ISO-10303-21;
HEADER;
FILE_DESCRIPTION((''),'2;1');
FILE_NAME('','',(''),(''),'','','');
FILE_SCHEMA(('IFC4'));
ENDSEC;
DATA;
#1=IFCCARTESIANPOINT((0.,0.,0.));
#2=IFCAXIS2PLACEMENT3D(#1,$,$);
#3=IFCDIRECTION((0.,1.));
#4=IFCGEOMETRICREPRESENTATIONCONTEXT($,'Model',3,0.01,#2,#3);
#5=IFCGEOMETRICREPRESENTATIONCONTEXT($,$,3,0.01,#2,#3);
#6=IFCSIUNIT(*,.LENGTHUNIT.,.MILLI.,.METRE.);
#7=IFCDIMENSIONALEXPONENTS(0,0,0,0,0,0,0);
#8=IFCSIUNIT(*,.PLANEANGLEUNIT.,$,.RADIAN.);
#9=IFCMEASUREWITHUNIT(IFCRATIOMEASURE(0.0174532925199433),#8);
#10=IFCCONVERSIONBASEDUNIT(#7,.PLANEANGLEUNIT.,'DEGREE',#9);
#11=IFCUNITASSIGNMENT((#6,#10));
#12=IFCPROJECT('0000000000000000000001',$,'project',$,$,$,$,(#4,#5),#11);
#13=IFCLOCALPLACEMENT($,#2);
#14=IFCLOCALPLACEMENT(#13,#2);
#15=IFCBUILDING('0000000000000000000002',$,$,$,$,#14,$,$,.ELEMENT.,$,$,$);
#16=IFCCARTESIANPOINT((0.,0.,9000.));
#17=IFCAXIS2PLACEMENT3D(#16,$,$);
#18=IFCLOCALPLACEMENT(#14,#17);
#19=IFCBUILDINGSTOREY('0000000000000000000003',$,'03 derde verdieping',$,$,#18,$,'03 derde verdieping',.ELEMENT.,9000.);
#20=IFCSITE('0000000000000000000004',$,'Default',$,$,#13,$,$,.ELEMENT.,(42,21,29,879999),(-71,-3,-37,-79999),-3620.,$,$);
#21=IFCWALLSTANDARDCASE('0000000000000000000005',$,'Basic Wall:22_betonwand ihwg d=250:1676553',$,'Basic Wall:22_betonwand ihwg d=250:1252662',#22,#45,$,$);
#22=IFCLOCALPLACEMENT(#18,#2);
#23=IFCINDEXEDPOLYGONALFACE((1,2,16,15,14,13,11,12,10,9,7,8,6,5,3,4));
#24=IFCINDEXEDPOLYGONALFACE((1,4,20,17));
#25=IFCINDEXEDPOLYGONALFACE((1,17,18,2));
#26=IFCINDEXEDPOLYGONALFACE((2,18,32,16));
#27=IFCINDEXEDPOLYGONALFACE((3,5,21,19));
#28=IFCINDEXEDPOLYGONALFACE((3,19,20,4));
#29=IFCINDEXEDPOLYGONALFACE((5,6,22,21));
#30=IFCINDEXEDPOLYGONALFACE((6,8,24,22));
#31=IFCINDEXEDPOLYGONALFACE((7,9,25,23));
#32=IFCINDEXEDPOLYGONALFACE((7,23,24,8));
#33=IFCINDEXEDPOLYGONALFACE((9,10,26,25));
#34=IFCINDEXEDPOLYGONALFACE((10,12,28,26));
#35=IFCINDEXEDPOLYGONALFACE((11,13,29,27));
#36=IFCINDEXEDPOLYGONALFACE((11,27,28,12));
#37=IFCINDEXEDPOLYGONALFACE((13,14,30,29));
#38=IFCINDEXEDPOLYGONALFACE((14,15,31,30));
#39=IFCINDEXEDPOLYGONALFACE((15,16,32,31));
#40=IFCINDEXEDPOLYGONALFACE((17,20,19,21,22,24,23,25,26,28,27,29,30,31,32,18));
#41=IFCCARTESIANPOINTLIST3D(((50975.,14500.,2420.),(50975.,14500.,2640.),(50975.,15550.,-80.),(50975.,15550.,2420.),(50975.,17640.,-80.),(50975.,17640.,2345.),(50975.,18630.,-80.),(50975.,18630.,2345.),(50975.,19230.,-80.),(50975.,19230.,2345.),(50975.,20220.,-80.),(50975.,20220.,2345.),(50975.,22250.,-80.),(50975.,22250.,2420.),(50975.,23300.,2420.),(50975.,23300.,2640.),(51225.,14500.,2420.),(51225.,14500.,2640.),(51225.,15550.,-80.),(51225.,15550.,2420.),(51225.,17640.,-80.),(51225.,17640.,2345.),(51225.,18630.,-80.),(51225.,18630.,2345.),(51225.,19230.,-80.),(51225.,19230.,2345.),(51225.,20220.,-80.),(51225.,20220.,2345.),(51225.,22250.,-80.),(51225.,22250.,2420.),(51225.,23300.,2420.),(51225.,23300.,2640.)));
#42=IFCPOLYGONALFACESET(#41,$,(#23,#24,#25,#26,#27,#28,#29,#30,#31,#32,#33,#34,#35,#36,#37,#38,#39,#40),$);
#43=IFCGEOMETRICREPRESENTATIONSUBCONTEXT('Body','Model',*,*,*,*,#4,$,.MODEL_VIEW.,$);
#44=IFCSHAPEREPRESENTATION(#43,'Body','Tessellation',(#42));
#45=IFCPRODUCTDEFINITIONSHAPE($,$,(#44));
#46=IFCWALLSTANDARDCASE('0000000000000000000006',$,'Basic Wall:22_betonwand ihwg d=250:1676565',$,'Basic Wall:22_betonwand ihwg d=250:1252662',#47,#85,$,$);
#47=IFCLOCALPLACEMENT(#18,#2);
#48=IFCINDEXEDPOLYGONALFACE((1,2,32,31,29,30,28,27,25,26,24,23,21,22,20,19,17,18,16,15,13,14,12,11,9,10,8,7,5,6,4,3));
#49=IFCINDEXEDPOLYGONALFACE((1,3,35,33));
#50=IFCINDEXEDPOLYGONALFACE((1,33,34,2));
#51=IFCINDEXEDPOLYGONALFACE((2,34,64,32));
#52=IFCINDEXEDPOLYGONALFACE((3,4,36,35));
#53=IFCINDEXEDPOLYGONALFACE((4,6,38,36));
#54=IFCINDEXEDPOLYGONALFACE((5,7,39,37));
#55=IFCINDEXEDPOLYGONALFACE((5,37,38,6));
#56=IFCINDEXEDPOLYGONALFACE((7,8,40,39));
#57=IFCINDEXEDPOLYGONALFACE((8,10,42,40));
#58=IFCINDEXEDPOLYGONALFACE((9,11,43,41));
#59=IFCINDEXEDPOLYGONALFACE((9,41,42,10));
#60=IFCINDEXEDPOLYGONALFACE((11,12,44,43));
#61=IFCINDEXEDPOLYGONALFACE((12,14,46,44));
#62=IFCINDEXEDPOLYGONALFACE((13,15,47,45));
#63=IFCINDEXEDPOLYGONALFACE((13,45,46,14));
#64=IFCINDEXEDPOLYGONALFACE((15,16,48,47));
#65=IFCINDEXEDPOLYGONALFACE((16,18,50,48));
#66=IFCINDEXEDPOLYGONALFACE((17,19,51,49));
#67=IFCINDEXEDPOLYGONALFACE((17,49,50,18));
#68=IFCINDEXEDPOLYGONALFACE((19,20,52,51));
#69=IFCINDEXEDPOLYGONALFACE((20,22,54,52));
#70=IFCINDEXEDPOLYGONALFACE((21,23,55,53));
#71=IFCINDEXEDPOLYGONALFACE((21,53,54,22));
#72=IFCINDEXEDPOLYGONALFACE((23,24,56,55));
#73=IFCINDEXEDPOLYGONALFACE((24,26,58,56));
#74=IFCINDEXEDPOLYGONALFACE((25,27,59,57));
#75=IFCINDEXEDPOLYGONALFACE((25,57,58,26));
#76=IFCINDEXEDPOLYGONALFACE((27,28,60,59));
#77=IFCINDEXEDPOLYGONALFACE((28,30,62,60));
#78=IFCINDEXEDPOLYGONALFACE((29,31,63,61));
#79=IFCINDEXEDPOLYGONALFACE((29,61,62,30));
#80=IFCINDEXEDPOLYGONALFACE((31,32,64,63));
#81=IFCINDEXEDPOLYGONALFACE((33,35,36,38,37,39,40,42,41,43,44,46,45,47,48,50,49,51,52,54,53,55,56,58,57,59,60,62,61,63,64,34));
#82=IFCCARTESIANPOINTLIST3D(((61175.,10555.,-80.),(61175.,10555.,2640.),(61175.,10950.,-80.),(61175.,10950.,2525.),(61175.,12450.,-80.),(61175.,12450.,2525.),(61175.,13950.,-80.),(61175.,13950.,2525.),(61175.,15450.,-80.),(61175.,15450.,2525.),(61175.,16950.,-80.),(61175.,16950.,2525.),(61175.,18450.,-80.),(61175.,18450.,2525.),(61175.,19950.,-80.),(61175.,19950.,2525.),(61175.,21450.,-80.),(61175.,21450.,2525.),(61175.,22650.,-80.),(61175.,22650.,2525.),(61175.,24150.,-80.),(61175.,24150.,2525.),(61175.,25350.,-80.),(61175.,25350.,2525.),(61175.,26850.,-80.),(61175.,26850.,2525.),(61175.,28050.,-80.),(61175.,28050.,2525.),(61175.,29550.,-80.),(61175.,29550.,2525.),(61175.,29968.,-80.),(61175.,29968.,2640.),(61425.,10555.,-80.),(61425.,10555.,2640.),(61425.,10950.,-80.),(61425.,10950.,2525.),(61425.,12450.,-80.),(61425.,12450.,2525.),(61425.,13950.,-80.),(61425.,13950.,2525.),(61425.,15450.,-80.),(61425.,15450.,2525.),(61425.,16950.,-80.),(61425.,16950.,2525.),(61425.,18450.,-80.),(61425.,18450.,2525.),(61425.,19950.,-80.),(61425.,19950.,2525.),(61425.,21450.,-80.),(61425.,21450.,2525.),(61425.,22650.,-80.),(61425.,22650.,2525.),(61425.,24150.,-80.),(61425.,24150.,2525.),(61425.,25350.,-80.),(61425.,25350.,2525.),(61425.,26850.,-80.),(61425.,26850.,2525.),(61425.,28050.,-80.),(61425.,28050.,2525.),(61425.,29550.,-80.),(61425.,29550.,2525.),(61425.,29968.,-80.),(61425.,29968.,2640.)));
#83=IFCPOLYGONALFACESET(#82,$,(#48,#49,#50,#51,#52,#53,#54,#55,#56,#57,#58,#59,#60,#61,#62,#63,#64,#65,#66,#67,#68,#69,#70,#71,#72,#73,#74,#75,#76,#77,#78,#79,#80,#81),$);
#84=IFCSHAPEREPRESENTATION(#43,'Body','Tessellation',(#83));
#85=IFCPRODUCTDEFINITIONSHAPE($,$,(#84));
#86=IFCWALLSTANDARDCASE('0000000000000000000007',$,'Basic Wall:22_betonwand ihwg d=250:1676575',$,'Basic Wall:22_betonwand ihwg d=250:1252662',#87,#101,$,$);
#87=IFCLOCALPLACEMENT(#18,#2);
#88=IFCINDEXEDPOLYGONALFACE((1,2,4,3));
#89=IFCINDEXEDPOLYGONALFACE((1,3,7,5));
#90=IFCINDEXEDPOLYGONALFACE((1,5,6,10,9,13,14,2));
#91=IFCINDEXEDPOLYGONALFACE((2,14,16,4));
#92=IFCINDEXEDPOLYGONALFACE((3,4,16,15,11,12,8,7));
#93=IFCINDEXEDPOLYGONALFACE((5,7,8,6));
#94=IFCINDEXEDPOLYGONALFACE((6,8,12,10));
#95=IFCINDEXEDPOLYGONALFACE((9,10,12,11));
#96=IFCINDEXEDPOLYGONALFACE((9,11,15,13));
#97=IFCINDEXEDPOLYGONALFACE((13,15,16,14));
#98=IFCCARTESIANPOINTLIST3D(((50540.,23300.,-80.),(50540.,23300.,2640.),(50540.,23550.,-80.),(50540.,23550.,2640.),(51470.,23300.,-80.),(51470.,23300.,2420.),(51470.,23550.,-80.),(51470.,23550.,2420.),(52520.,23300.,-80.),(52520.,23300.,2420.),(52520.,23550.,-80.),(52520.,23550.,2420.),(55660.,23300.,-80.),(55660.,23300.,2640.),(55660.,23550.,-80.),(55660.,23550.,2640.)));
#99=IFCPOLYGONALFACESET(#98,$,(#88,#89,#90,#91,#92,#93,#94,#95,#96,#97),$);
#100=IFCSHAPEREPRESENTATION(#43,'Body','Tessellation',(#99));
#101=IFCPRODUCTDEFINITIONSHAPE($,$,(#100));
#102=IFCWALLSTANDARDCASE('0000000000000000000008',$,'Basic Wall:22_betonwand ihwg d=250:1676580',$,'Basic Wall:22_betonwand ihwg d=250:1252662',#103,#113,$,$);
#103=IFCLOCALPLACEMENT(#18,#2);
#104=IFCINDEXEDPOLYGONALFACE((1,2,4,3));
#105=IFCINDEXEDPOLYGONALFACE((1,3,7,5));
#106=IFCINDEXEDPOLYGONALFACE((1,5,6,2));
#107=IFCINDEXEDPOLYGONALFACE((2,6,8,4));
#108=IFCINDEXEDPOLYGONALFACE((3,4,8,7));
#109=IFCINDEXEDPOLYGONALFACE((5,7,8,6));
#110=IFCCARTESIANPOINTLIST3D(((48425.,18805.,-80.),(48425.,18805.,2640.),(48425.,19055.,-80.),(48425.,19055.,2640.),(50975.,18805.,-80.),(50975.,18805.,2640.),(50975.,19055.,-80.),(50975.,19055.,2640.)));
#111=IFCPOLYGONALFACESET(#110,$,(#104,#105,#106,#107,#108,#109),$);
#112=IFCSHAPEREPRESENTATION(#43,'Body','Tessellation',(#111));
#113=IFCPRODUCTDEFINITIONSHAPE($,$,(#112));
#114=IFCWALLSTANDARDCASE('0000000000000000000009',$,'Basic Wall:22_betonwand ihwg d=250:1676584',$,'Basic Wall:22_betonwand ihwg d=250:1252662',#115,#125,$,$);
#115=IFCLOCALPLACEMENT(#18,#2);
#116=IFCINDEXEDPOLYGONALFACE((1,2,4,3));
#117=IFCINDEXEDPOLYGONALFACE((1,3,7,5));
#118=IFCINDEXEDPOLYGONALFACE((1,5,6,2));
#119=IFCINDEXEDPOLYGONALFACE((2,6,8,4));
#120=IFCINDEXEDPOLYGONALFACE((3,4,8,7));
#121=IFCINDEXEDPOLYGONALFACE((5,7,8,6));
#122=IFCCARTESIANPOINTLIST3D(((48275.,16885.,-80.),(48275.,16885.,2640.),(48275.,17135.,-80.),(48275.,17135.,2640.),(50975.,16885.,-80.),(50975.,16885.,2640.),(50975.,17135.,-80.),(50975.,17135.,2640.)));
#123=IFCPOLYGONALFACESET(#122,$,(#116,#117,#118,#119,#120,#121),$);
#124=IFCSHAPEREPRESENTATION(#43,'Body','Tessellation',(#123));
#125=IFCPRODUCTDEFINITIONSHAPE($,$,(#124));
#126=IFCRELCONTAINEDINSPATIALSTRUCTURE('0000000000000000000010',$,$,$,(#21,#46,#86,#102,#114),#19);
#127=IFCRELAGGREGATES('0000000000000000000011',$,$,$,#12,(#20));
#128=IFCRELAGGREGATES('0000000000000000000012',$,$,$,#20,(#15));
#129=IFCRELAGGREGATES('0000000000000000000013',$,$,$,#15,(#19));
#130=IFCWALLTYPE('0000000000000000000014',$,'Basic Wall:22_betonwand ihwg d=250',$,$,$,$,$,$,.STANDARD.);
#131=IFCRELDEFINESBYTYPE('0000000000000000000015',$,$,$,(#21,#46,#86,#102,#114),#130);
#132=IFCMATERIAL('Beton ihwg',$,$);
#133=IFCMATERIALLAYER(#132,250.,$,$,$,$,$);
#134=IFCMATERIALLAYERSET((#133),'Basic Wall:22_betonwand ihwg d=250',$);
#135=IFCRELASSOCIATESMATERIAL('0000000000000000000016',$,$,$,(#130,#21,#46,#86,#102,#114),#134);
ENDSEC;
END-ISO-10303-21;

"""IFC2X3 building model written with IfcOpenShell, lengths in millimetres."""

from ifc_helpers import new_model, entity, si_unit, converted_unit, direction, frame, frame_2d, origin, place, context, subcontext, project, spatial, rectangle, extrude, material, layer, layer_set, layer_usage, type_object, element, save


model = new_model("IFC2X3")

# Units and contexts
model_context = context("Model", 3, precision=0.01, world=origin(), true_north=direction((0.0, 1.0)))
context_of_model = context(None, 3, precision=0.01, world=origin(), true_north=direction((0.0, 1.0)))
body_context = subcontext(model_context, "Body", "Model", "MODEL_VIEW")
ifc_project = project(units=[si_unit("LENGTHUNIT", "METRE", prefix="MILLI"), converted_unit("PLANEANGLEUNIT", "DEGREE", entity("IfcRatioMeasure", 0.0174532925199433), si_unit("PLANEANGLEUNIT", "RADIAN"), dimensions=[0, 0, 0, 0, 0, 0, 0])], contexts=[model_context, context_of_model])

# Site, building, storey
site_placement = place(None, origin())
site = spatial("IfcSite", under=ifc_project, at=site_placement, Name="Default", CompositionType="ELEMENT", RefLatitude=(42, 21, 29, 879999), RefLongitude=(-71, -3, -37, -79999), RefElevation=-3620.0)
building_placement = place(site_placement, origin())
building = spatial("IfcBuilding", under=site, at=building_placement, CompositionType="ELEMENT")
storey_placement = place(building_placement, frame((0.0, 0.0, 9000.0)))
storey = spatial("IfcBuildingStorey", under=building, at=storey_placement, Name="03 derde verdieping", LongName="03 derde verdieping", CompositionType="ELEMENT", Elevation=9000.0)

# Walls, openings
ifc_material_1 = material(Name="Beton ihwg")
ifc_layer_1 = layer(ifc_material_1, 250.0)
ifc_layer_set_1 = layer_set([ifc_layer_1], Name="Basic Wall:22_betonwand ihwg d=250")
ifc_layer_usage_1 = layer_usage(ifc_layer_set_1, "AXIS2", "NEGATIVE", 125.0)
wall_type_1 = type_object("IfcWallType", Name="Basic Wall:22_betonwand ihwg d=250", PredefinedType="STANDARD", material=ifc_layer_set_1)
wall_1_placement = place(storey_placement, frame((51100.0, 23300.0, -80.0), z_axis=(0.0, 0.0, 1.0), x_axis=(0.0, -1.0, 0.0)))
wall_1 = element("IfcWallStandardCase", 1, at=wall_1_placement, inside=storey, type_object=wall_type_1, material=ifc_layer_usage_1, Name="Basic Wall:22_betonwand ihwg d=250:1676553", ObjectType="Basic Wall:22_betonwand ihwg d=250:1252662", context=body_context, shape_type="SweptSolid", body=[
    extrude(rectangle(XDim=8800.0, YDim=250.0, at=frame_2d((4400.0, 0.0), x_axis=(-1.0, 0.0))), origin(), (0.0, 0.0, 1.0), 2720.0),
])
opening_1_placement = place(wall_1_placement, frame((23300.0, -51100.0, 80.0), z_axis=(0.0, 0.0, 1.0), x_axis=(0.0, 1.0, 0.0)))
element("IfcOpeningElement", 2, at=opening_1_placement, cuts=wall_1, ObjectType="Opening", context=body_context, shape_type="SweptSolid", body=[
    extrude(rectangle(XDim=2500.0, YDim=1050.0, at=frame_2d((0.0, 0.0), x_axis=(0.0, 1.0))), frame((50700.0, 15025.0, 1170.0), z_axis=(1.0, 0.0, 0.0), x_axis=(0.0, -1.0, 0.0)), (0.0, 0.0, 1.0), 800.0),
])
opening_2_placement = place(wall_1_placement, frame((23300.0, -51100.0, 80.0), z_axis=(0.0, 0.0, 1.0), x_axis=(0.0, 1.0, 0.0)))
element("IfcOpeningElement", 3, at=opening_2_placement, cuts=wall_1, ObjectType="Opening", context=body_context, shape_type="SweptSolid", body=[
    extrude(rectangle(XDim=2425.0, YDim=990.0, at=frame_2d((0.0, 0.0), x_axis=(1.0, 0.0))), frame((50700.0, 19725.0, 1132.5), z_axis=(1.0, 0.0, 0.0), x_axis=(0.0, 0.0, -1.0)), (0.0, 0.0, 1.0), 800.0),
])
opening_3_placement = place(wall_1_placement, frame((23300.0, -51100.0, 80.0), z_axis=(0.0, 0.0, 1.0), x_axis=(0.0, 1.0, 0.0)))
element("IfcOpeningElement", 4, at=opening_3_placement, cuts=wall_1, ObjectType="Opening", context=body_context, shape_type="SweptSolid", body=[
    extrude(rectangle(XDim=2425.0, YDim=990.0, at=frame_2d((0.0, 0.0), x_axis=(1.0, 0.0))), frame((50700.0, 18135.0, 1132.5), z_axis=(1.0, 0.0, 0.0), x_axis=(0.0, 0.0, -1.0)), (0.0, 0.0, 1.0), 800.0),
])
opening_4_placement = place(wall_1_placement, frame((23300.0, -51100.0, 80.0), z_axis=(0.0, 0.0, 1.0), x_axis=(0.0, 1.0, 0.0)))
element("IfcOpeningElement", 5, at=opening_4_placement, cuts=wall_1, ObjectType="Opening", context=body_context, shape_type="SweptSolid", body=[
    extrude(rectangle(XDim=2500.0, YDim=1050.0, at=frame_2d((0.0, 0.0), x_axis=(1.0, 0.0))), frame((50700.0, 22775.0, 1170.0), z_axis=(1.0, 0.0, 0.0), x_axis=(0.0, 0.0, -1.0)), (0.0, 0.0, 1.0), 800.0),
])
ifc_layer_usage_2 = layer_usage(ifc_layer_set_1, "AXIS2", "POSITIVE", -125.0)
wall_2_placement = place(storey_placement, frame((61300.0, 29968.0, -80.0), z_axis=(0.0, 0.0, 1.0), x_axis=(0.0, -1.0, 0.0)))
wall_2 = element("IfcWallStandardCase", 6, at=wall_2_placement, inside=storey, type_object=wall_type_1, material=ifc_layer_usage_2, Name="Basic Wall:22_betonwand ihwg d=250:1676565", ObjectType="Basic Wall:22_betonwand ihwg d=250:1252662", context=body_context, shape_type="SweptSolid", body=[
    extrude(rectangle(XDim=19413.0, YDim=250.0, at=frame_2d((9706.5, 0.0), x_axis=(-1.0, 0.0))), origin(), (0.0, 0.0, 1.0), 2720.0),
])
opening_5_placement = place(wall_2_placement, frame((29968.0, -61300.0, 80.0), z_axis=(0.0, 0.0, 1.0), x_axis=(0.0, 1.0, 0.0)))
element("IfcOpeningElement", 7, at=opening_5_placement, cuts=wall_2, ObjectType="Opening", context=body_context, shape_type="SweptSolid", body=[
    extrude(rectangle(XDim=2605.0, YDim=1500.0, at=frame_2d((0.0, 0.0), x_axis=(1.0, 0.0))), frame((59901.0, 28800.0, 1222.5), z_axis=(1.0, 0.0, 0.0), x_axis=(0.0, 0.0, -1.0)), (0.0, 0.0, 1.0), 3048.0),
])
opening_6_placement = place(wall_2_placement, frame((29968.0, -61300.0, 80.0), z_axis=(0.0, 0.0, 1.0), x_axis=(0.0, 1.0, 0.0)))
element("IfcOpeningElement", 8, at=opening_6_placement, cuts=wall_2, ObjectType="Opening", context=body_context, shape_type="SweptSolid", body=[
    extrude(rectangle(XDim=2605.0, YDim=1500.0, at=frame_2d((0.0, 0.0), x_axis=(1.0, 0.0))), frame((59901.0, 26100.0, 1222.5), z_axis=(1.0, 0.0, 0.0), x_axis=(0.0, 0.0, -1.0)), (0.0, 0.0, 1.0), 3048.0),
])
opening_7_placement = place(wall_2_placement, frame((29968.0, -61300.0, 80.0), z_axis=(0.0, 0.0, 1.0), x_axis=(0.0, 1.0, 0.0)))
element("IfcOpeningElement", 9, at=opening_7_placement, cuts=wall_2, ObjectType="Opening", context=body_context, shape_type="SweptSolid", body=[
    extrude(rectangle(XDim=2605.0, YDim=1500.0, at=frame_2d((0.0, 0.0), x_axis=(1.0, 0.0))), frame((59901.0, 23400.0, 1222.5), z_axis=(1.0, 0.0, 0.0), x_axis=(0.0, 0.0, -1.0)), (0.0, 0.0, 1.0), 3048.0),
])
opening_8_placement = place(wall_2_placement, frame((29968.0, -61300.0, 80.0), z_axis=(0.0, 0.0, 1.0), x_axis=(0.0, 1.0, 0.0)))
element("IfcOpeningElement", 10, at=opening_8_placement, cuts=wall_2, ObjectType="Opening", context=body_context, shape_type="SweptSolid", body=[
    extrude(rectangle(XDim=2605.0, YDim=1500.0, at=frame_2d((0.0, 0.0), x_axis=(1.0, 0.0))), frame((59901.0, 17700.0, 1222.5), z_axis=(1.0, 0.0, 0.0), x_axis=(0.0, 0.0, -1.0)), (0.0, 0.0, 1.0), 3048.0),
])
opening_9_placement = place(wall_2_placement, frame((29968.0, -61300.0, 80.0), z_axis=(0.0, 0.0, 1.0), x_axis=(0.0, 1.0, 0.0)))
element("IfcOpeningElement", 11, at=opening_9_placement, cuts=wall_2, ObjectType="Opening", context=body_context, shape_type="SweptSolid", body=[
    extrude(rectangle(XDim=2605.0, YDim=1500.0, at=frame_2d((0.0, 0.0), x_axis=(1.0, 0.0))), frame((59901.0, 14700.0, 1222.5), z_axis=(1.0, 0.0, 0.0), x_axis=(0.0, 0.0, -1.0)), (0.0, 0.0, 1.0), 3048.0),
])
opening_10_placement = place(wall_2_placement, frame((29968.0, -61300.0, 80.0), z_axis=(0.0, 0.0, 1.0), x_axis=(0.0, 1.0, 0.0)))
element("IfcOpeningElement", 12, at=opening_10_placement, cuts=wall_2, ObjectType="Opening", context=body_context, shape_type="SweptSolid", body=[
    extrude(rectangle(XDim=2605.0, YDim=1500.0, at=frame_2d((0.0, 0.0), x_axis=(1.0, 0.0))), frame((59901.0, 20700.0, 1222.5), z_axis=(1.0, 0.0, 0.0), x_axis=(0.0, 0.0, -1.0)), (0.0, 0.0, 1.0), 3048.0),
])
opening_11_placement = place(wall_2_placement, frame((29968.0, -61300.0, 80.0), z_axis=(0.0, 0.0, 1.0), x_axis=(0.0, 1.0, 0.0)))
element("IfcOpeningElement", 13, at=opening_11_placement, cuts=wall_2, ObjectType="Opening", context=body_context, shape_type="SweptSolid", body=[
    extrude(rectangle(XDim=2605.0, YDim=1500.0, at=frame_2d((0.0, 0.0), x_axis=(1.0, 0.0))), frame((59901.0, 11700.0, 1222.5), z_axis=(1.0, 0.0, 0.0), x_axis=(0.0, 0.0, -1.0)), (0.0, 0.0, 1.0), 3048.0),
])
ifc_layer_usage_3 = layer_usage(ifc_layer_set_1, "AXIS2", "POSITIVE", -125.0)
wall_3_placement = place(storey_placement, frame((55660.0, 23425.0, -80.0), z_axis=(0.0, 0.0, 1.0), x_axis=(-1.0, 0.0, 0.0)))
wall_3 = element("IfcWallStandardCase", 14, at=wall_3_placement, inside=storey, type_object=wall_type_1, material=ifc_layer_usage_3, Name="Basic Wall:22_betonwand ihwg d=250:1676575", ObjectType="Basic Wall:22_betonwand ihwg d=250:1252662", context=body_context, shape_type="SweptSolid", body=[
    extrude(rectangle(XDim=5120.0, YDim=250.0, at=frame_2d((2560.0, 0.0), x_axis=(-1.0, 0.0))), origin(), (0.0, 0.0, 1.0), 2720.0),
])
opening_12_placement = place(wall_3_placement, origin())
element("IfcOpeningElement", 15, at=opening_12_placement, cuts=wall_3, ObjectType="Opening", context=body_context, shape_type="SweptSolid", body=[
    extrude(rectangle(XDim=2500.0, YDim=800.0, at=frame_2d((0.0, 0.0), x_axis=(0.0, 1.0))), frame((4560.0, 125.0, 1250.0), z_axis=(0.0, 1.0, 0.0), x_axis=(1.0, 0.0, 0.0)), (0.0, 0.0, 1.0), 1050.0),
])
opening_13_placement = place(wall_3_placement, origin())
element("IfcOpeningElement", 16, at=opening_13_placement, cuts=wall_3, ObjectType="Opening", context=body_context, shape_type="SweptSolid", body=[
    extrude(rectangle(XDim=2500.0, YDim=800.0, at=frame_2d((0.0, 0.0), x_axis=(0.0, 1.0))), frame((2735.0, 125.0, 1250.0), z_axis=(0.0, 1.0, 0.0), x_axis=(1.0, 0.0, 0.0)), (0.0, 0.0, 1.0), 1034.0),
])
opening_14_placement = place(wall_3_placement, frame((55660.0, 23425.0, 80.0), z_axis=(0.0, 0.0, 1.0), x_axis=(-1.0, 0.0, 0.0)))
element("IfcOpeningElement", 17, at=opening_14_placement, cuts=wall_3, ObjectType="Opening", context=body_context, shape_type="SweptSolid", body=[
    extrude(rectangle(XDim=2500.0, YDim=1050.0, at=frame_2d((0.0, 0.0), x_axis=(0.0, 1.0))), frame((51995.0, 23825.0, 1170.0), z_axis=(0.0, -1.0, 0.0), x_axis=(-1.0, 0.0, 0.0)), (0.0, 0.0, 1.0), 800.0),
])

# Walls
ifc_layer_usage_4 = layer_usage(ifc_layer_set_1, "AXIS2", "POSITIVE", -125.0)
wall_4_placement = place(storey_placement, frame((50975.0, 18930.0, -80.0), z_axis=(0.0, 0.0, 1.0), x_axis=(-1.0, 0.0, 0.0)))
element("IfcWallStandardCase", 18, at=wall_4_placement, inside=storey, type_object=wall_type_1, material=ifc_layer_usage_4, Name="Basic Wall:22_betonwand ihwg d=250:1676580", ObjectType="Basic Wall:22_betonwand ihwg d=250:1252662", context=body_context, shape_type="SweptSolid", body=[
    extrude(rectangle(XDim=2550.0, YDim=250.0, at=frame_2d((1275.0, 0.0), x_axis=(-1.0, 0.0))), origin(), (0.0, 0.0, 1.0), 2720.0),
])
ifc_layer_usage_5 = layer_usage(ifc_layer_set_1, "AXIS2", "POSITIVE", -125.0)
wall_5_placement = place(storey_placement, frame((50975.0, 17010.0, -80.0), z_axis=(0.0, 0.0, 1.0), x_axis=(-1.0, 0.0, 0.0)))
element("IfcWallStandardCase", 19, at=wall_5_placement, inside=storey, type_object=wall_type_1, material=ifc_layer_usage_5, Name="Basic Wall:22_betonwand ihwg d=250:1676584", ObjectType="Basic Wall:22_betonwand ihwg d=250:1252662", context=body_context, shape_type="SweptSolid", body=[
    extrude(rectangle(XDim=2700.0, YDim=250.0, at=frame_2d((1350.0, 0.0), x_axis=(-1.0, 0.0))), origin(), (0.0, 0.0, 1.0), 2720.0),
])

save(model, "model.ifc")
